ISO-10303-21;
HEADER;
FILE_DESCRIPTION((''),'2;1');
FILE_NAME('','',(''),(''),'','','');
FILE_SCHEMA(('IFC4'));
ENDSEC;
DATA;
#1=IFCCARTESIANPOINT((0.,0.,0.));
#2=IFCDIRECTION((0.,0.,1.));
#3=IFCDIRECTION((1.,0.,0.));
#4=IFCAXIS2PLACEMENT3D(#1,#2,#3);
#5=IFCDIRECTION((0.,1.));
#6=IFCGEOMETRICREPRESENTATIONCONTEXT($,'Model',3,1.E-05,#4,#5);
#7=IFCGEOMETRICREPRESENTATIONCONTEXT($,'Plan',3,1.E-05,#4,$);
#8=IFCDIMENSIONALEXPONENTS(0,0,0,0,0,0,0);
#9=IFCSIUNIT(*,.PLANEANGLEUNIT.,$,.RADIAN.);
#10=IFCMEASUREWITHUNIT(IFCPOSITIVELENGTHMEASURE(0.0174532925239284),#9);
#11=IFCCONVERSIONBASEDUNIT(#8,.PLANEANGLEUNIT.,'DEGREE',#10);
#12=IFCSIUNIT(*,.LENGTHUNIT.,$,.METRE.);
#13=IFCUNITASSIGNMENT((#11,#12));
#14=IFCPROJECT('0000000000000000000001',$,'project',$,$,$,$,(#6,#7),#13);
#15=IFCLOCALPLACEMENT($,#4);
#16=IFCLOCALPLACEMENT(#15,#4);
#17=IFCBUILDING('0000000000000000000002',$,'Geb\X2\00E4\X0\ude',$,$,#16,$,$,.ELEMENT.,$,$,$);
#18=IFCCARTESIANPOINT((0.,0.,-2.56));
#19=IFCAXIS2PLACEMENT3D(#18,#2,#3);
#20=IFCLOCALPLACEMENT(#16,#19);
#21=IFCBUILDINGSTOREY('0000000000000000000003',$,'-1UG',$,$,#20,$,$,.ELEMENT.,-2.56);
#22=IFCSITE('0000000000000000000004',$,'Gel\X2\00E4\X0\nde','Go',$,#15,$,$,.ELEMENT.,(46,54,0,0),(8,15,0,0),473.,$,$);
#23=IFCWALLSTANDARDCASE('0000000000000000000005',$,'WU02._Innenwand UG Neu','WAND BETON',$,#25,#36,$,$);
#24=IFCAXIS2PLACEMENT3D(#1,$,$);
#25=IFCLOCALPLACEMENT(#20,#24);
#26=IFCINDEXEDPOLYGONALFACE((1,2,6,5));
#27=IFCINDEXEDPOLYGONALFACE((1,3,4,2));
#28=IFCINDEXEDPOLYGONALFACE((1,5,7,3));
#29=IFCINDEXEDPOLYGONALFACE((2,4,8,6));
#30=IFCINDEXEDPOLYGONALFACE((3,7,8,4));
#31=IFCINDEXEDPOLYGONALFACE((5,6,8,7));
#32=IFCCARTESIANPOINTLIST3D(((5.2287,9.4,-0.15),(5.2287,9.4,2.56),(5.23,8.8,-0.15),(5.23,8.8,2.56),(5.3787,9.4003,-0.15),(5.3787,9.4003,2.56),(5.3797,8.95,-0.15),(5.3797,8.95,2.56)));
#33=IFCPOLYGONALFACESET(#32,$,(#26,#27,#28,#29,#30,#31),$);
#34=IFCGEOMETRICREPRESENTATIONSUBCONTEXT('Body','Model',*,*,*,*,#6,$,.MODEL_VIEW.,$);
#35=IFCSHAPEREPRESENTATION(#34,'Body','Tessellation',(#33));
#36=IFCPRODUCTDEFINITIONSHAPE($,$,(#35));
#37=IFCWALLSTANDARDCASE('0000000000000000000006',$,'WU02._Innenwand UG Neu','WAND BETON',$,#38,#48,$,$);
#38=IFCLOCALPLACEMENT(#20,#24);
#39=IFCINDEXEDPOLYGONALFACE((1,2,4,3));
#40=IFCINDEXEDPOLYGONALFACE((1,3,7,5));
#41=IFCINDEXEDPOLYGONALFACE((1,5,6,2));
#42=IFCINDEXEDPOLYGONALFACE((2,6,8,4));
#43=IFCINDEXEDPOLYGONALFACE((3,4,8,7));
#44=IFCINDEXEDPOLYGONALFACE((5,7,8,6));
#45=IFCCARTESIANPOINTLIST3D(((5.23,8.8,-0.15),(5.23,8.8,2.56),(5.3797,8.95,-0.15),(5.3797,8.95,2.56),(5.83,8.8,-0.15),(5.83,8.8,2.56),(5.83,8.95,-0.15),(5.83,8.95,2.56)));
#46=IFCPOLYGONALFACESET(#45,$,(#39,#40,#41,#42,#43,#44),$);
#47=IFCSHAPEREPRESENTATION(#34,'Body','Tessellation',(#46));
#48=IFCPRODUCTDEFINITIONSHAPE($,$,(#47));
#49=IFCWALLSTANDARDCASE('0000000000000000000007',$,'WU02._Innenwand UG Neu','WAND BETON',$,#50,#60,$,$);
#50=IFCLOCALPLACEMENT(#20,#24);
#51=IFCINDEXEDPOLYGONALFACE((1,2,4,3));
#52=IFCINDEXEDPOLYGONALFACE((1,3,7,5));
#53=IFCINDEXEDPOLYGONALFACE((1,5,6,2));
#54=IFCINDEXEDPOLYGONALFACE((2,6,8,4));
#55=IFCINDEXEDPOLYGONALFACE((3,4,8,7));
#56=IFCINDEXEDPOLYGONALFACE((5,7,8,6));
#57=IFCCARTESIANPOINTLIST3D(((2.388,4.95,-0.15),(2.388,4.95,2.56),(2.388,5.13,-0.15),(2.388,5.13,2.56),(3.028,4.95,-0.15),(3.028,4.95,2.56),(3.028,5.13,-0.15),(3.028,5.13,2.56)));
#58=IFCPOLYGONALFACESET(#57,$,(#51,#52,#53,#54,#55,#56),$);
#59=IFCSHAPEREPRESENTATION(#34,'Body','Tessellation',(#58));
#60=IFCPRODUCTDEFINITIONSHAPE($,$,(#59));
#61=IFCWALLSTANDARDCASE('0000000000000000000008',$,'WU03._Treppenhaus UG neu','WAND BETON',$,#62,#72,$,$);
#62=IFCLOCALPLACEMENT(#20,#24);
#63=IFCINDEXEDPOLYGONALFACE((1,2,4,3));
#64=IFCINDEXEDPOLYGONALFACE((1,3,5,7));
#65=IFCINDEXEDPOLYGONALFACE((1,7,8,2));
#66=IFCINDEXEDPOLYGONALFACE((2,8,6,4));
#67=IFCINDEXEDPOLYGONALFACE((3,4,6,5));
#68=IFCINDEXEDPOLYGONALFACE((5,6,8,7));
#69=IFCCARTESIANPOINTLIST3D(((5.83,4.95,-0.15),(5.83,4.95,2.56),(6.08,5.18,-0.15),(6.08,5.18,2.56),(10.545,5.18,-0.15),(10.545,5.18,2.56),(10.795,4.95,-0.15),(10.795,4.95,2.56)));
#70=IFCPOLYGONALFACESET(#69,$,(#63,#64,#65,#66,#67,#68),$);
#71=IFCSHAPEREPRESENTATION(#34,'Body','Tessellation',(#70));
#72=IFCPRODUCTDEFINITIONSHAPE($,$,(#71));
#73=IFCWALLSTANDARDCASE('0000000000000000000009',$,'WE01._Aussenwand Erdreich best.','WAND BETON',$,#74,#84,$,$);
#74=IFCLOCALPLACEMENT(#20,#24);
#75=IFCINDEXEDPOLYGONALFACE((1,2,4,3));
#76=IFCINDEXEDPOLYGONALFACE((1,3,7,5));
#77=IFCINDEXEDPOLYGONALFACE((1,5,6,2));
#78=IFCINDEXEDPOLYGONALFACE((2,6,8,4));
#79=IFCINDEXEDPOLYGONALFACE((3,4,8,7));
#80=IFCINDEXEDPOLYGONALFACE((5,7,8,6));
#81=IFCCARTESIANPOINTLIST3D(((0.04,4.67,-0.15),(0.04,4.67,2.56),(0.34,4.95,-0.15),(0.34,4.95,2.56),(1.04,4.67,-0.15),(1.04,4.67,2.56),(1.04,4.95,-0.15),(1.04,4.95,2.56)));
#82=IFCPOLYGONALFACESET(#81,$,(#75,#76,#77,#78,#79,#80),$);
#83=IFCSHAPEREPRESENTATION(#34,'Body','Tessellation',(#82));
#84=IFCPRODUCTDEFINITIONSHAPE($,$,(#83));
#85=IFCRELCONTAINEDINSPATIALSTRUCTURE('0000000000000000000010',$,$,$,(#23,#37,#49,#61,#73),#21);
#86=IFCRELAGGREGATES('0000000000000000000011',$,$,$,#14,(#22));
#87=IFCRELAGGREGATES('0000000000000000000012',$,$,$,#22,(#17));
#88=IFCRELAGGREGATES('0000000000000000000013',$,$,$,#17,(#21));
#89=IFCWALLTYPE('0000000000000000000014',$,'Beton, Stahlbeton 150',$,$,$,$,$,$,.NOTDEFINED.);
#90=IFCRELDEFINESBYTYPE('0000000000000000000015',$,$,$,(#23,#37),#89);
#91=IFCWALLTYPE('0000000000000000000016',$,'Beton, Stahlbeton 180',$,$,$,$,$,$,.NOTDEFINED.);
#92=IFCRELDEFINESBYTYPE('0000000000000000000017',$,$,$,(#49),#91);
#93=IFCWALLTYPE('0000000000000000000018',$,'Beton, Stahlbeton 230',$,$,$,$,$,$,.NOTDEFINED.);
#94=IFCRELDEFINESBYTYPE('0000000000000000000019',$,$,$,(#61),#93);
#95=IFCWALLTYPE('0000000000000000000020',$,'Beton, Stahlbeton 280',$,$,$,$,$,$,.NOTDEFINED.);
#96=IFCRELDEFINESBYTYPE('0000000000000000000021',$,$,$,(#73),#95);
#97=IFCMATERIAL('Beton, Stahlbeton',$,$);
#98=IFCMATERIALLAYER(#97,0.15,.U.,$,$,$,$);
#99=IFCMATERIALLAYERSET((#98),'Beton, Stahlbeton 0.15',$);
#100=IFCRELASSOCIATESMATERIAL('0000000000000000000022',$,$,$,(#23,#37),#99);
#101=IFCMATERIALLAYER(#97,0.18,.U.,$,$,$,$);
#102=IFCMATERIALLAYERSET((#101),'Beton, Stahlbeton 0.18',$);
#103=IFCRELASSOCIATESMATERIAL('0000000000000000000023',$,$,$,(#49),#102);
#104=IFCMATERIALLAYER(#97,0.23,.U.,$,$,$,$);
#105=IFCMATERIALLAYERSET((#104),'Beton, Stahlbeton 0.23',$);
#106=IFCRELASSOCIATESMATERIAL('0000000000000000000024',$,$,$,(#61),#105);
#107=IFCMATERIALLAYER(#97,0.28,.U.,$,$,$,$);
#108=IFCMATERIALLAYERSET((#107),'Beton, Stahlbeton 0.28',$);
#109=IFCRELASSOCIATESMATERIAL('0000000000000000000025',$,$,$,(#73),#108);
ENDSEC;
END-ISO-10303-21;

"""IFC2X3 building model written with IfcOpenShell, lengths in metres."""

from ifc_helpers import new_model, entity, si_unit, converted_unit, direction, frame, origin_with_axes, place, context, subcontext, project, spatial, polyline, outline, extrude, material, layer, layer_set, layer_usage, type_object, element, save


model = new_model("IFC2X3")

# Units and contexts
model_context = context("Model", 3, precision=1e-05, world=origin_with_axes(), true_north=direction((0.0, 1.0)))
plan_context = context("Plan", 3, precision=1e-05, world=origin_with_axes())
body_context = subcontext(model_context, "Body", "Model", "MODEL_VIEW")
ifc_project = project(units=[converted_unit("PLANEANGLEUNIT", "DEGREE", entity("IfcPositiveLengthMeasure", 0.0174532925239284), si_unit("PLANEANGLEUNIT", "RADIAN"), dimensions=[0, 0, 0, 0, 0, 0, 0]), si_unit("LENGTHUNIT", "METRE")], contexts=[model_context, plan_context])

# Site, building, storey
site_placement = place(None, origin_with_axes())
site = spatial("IfcSite", under=ifc_project, at=site_placement, Name="Gelände", Description="Go", CompositionType="ELEMENT", RefLatitude=(46, 54, 0, 0), RefLongitude=(8, 15, 0, 0), RefElevation=473.0)
building_placement = place(site_placement, origin_with_axes())
building = spatial("IfcBuilding", under=site, at=building_placement, Name="Gebäude", CompositionType="ELEMENT")
storey_placement = place(building_placement, frame((0.0, 0.0, -2.56), z_axis=(0.0, 0.0, 1.0), x_axis=(1.0, 0.0, 0.0)))
storey = spatial("IfcBuildingStorey", under=building, at=storey_placement, Name="-1UG", CompositionType="ELEMENT", Elevation=-2.56)

# Shared definitions
ifc_material_1 = material(Name="Beton, Stahlbeton")

# Walls
ifc_layer_1 = layer(ifc_material_1, 0.15, ventilated="UNKNOWN")
ifc_layer_set_1 = layer_set([ifc_layer_1], Name="Beton, Stahlbeton 0.15")
wall_type_1 = type_object("IfcWallType", Name="Beton, Stahlbeton 150", PredefinedType="NOTDEFINED")
ifc_layer_usage_1 = layer_usage(ifc_layer_set_1, "AXIS2", "POSITIVE", 0.0)
wall_1_placement = place(storey_placement, frame((5.2287, 9.4, -0.15), z_axis=(0.0, 0.0, 1.0), x_axis=(0.002118, -0.999998, 0.0)))
element("IfcWallStandardCase", 1, at=wall_1_placement, inside=storey, type_object=wall_type_1, material=ifc_layer_usage_1, Name="WU02._Innenwand UG Neu", Description="WAND BETON", context=body_context, shape_type="SweptSolid", body=[
    extrude(outline(polyline([(0.0, 0.0), (0.6, 0.0), (0.4503, 0.15), (0.0, 0.15), (0.0, 0.0)])), origin_with_axes(), (0.0, 0.0, 1.0), 2.71),
])
ifc_layer_usage_2 = layer_usage(ifc_layer_set_1, "AXIS2", "POSITIVE", 0.0)
wall_2_placement = place(storey_placement, frame((5.23, 8.8, -0.15), z_axis=(0.0, 0.0, 1.0), x_axis=(1.0, 0.0, 0.0)))
element("IfcWallStandardCase", 2, at=wall_2_placement, inside=storey, type_object=wall_type_1, material=ifc_layer_usage_2, Name="WU02._Innenwand UG Neu", Description="WAND BETON", context=body_context, shape_type="SweptSolid", body=[
    extrude(outline(polyline([(0.0, 0.0), (0.6, 0.0), (0.6, 0.15), (0.1497, 0.15), (0.0, 0.0)])), origin_with_axes(), (0.0, 0.0, 1.0), 2.71),
])
ifc_layer_2 = layer(ifc_material_1, 0.18, ventilated="UNKNOWN")
ifc_layer_set_2 = layer_set([ifc_layer_2], Name="Beton, Stahlbeton 0.18")
ifc_layer_usage_3 = layer_usage(ifc_layer_set_2, "AXIS2", "NEGATIVE", 0.0)
wall_type_2 = type_object("IfcWallType", Name="Beton, Stahlbeton 180", PredefinedType="NOTDEFINED")
wall_3_placement = place(storey_placement, frame((3.028, 4.95, -0.15), z_axis=(0.0, 0.0, 1.0), x_axis=(-1.0, 0.0, 0.0)))
element("IfcWallStandardCase", 3, at=wall_3_placement, inside=storey, type_object=wall_type_2, material=ifc_layer_usage_3, Name="WU02._Innenwand UG Neu", Description="WAND BETON", context=body_context, shape_type="SweptSolid", body=[
    extrude(outline(polyline([(0.0, -0.18), (0.64, -0.18), (0.64, 0.0), (0.0, 0.0), (0.0, -0.18)])), origin_with_axes(), (0.0, 0.0, 1.0), 2.71),
])
ifc_layer_3 = layer(ifc_material_1, 0.23, ventilated="UNKNOWN")
ifc_layer_set_3 = layer_set([ifc_layer_3], Name="Beton, Stahlbeton 0.23")
ifc_layer_usage_4 = layer_usage(ifc_layer_set_3, "AXIS2", "POSITIVE", -0.23)
wall_type_3 = type_object("IfcWallType", Name="Beton, Stahlbeton 230", PredefinedType="NOTDEFINED")
wall_4_placement = place(storey_placement, frame((6.08, 5.18, -0.15), z_axis=(0.0, 0.0, 1.0), x_axis=(1.0, 0.0, 0.0)))
element("IfcWallStandardCase", 4, at=wall_4_placement, inside=storey, type_object=wall_type_3, material=ifc_layer_usage_4, Name="WU03._Treppenhaus UG neu", Description="WAND BETON", context=body_context, shape_type="SweptSolid", body=[
    extrude(outline(polyline([(-0.25, -0.23), (4.715, -0.23), (4.465, 0.0), (0.0, 0.0), (-0.25, -0.23)])), origin_with_axes(), (0.0, 0.0, 1.0), 2.71),
])
ifc_layer_4 = layer(ifc_material_1, 0.28, ventilated="UNKNOWN")
ifc_layer_set_4 = layer_set([ifc_layer_4], Name="Beton, Stahlbeton 0.28")
ifc_layer_usage_5 = layer_usage(ifc_layer_set_4, "AXIS2", "POSITIVE", -0.28)
wall_type_4 = type_object("IfcWallType", Name="Beton, Stahlbeton 280", PredefinedType="NOTDEFINED")
wall_5_placement = place(storey_placement, frame((0.34, 4.95, -0.15), z_axis=(0.0, 0.0, 1.0), x_axis=(1.0, 0.0, 0.0)))
element("IfcWallStandardCase", 5, at=wall_5_placement, inside=storey, type_object=wall_type_4, material=ifc_layer_usage_5, Name="WE01._Aussenwand Erdreich best.", Description="WAND BETON", context=body_context, shape_type="SweptSolid", body=[
    extrude(outline(polyline([(-0.3, -0.28), (0.7, -0.28), (0.7, 0.0), (0.0, 0.0), (-0.3, -0.28)])), origin_with_axes(), (0.0, 0.0, 1.0), 2.71),
])

save(model, "model.ifc")
